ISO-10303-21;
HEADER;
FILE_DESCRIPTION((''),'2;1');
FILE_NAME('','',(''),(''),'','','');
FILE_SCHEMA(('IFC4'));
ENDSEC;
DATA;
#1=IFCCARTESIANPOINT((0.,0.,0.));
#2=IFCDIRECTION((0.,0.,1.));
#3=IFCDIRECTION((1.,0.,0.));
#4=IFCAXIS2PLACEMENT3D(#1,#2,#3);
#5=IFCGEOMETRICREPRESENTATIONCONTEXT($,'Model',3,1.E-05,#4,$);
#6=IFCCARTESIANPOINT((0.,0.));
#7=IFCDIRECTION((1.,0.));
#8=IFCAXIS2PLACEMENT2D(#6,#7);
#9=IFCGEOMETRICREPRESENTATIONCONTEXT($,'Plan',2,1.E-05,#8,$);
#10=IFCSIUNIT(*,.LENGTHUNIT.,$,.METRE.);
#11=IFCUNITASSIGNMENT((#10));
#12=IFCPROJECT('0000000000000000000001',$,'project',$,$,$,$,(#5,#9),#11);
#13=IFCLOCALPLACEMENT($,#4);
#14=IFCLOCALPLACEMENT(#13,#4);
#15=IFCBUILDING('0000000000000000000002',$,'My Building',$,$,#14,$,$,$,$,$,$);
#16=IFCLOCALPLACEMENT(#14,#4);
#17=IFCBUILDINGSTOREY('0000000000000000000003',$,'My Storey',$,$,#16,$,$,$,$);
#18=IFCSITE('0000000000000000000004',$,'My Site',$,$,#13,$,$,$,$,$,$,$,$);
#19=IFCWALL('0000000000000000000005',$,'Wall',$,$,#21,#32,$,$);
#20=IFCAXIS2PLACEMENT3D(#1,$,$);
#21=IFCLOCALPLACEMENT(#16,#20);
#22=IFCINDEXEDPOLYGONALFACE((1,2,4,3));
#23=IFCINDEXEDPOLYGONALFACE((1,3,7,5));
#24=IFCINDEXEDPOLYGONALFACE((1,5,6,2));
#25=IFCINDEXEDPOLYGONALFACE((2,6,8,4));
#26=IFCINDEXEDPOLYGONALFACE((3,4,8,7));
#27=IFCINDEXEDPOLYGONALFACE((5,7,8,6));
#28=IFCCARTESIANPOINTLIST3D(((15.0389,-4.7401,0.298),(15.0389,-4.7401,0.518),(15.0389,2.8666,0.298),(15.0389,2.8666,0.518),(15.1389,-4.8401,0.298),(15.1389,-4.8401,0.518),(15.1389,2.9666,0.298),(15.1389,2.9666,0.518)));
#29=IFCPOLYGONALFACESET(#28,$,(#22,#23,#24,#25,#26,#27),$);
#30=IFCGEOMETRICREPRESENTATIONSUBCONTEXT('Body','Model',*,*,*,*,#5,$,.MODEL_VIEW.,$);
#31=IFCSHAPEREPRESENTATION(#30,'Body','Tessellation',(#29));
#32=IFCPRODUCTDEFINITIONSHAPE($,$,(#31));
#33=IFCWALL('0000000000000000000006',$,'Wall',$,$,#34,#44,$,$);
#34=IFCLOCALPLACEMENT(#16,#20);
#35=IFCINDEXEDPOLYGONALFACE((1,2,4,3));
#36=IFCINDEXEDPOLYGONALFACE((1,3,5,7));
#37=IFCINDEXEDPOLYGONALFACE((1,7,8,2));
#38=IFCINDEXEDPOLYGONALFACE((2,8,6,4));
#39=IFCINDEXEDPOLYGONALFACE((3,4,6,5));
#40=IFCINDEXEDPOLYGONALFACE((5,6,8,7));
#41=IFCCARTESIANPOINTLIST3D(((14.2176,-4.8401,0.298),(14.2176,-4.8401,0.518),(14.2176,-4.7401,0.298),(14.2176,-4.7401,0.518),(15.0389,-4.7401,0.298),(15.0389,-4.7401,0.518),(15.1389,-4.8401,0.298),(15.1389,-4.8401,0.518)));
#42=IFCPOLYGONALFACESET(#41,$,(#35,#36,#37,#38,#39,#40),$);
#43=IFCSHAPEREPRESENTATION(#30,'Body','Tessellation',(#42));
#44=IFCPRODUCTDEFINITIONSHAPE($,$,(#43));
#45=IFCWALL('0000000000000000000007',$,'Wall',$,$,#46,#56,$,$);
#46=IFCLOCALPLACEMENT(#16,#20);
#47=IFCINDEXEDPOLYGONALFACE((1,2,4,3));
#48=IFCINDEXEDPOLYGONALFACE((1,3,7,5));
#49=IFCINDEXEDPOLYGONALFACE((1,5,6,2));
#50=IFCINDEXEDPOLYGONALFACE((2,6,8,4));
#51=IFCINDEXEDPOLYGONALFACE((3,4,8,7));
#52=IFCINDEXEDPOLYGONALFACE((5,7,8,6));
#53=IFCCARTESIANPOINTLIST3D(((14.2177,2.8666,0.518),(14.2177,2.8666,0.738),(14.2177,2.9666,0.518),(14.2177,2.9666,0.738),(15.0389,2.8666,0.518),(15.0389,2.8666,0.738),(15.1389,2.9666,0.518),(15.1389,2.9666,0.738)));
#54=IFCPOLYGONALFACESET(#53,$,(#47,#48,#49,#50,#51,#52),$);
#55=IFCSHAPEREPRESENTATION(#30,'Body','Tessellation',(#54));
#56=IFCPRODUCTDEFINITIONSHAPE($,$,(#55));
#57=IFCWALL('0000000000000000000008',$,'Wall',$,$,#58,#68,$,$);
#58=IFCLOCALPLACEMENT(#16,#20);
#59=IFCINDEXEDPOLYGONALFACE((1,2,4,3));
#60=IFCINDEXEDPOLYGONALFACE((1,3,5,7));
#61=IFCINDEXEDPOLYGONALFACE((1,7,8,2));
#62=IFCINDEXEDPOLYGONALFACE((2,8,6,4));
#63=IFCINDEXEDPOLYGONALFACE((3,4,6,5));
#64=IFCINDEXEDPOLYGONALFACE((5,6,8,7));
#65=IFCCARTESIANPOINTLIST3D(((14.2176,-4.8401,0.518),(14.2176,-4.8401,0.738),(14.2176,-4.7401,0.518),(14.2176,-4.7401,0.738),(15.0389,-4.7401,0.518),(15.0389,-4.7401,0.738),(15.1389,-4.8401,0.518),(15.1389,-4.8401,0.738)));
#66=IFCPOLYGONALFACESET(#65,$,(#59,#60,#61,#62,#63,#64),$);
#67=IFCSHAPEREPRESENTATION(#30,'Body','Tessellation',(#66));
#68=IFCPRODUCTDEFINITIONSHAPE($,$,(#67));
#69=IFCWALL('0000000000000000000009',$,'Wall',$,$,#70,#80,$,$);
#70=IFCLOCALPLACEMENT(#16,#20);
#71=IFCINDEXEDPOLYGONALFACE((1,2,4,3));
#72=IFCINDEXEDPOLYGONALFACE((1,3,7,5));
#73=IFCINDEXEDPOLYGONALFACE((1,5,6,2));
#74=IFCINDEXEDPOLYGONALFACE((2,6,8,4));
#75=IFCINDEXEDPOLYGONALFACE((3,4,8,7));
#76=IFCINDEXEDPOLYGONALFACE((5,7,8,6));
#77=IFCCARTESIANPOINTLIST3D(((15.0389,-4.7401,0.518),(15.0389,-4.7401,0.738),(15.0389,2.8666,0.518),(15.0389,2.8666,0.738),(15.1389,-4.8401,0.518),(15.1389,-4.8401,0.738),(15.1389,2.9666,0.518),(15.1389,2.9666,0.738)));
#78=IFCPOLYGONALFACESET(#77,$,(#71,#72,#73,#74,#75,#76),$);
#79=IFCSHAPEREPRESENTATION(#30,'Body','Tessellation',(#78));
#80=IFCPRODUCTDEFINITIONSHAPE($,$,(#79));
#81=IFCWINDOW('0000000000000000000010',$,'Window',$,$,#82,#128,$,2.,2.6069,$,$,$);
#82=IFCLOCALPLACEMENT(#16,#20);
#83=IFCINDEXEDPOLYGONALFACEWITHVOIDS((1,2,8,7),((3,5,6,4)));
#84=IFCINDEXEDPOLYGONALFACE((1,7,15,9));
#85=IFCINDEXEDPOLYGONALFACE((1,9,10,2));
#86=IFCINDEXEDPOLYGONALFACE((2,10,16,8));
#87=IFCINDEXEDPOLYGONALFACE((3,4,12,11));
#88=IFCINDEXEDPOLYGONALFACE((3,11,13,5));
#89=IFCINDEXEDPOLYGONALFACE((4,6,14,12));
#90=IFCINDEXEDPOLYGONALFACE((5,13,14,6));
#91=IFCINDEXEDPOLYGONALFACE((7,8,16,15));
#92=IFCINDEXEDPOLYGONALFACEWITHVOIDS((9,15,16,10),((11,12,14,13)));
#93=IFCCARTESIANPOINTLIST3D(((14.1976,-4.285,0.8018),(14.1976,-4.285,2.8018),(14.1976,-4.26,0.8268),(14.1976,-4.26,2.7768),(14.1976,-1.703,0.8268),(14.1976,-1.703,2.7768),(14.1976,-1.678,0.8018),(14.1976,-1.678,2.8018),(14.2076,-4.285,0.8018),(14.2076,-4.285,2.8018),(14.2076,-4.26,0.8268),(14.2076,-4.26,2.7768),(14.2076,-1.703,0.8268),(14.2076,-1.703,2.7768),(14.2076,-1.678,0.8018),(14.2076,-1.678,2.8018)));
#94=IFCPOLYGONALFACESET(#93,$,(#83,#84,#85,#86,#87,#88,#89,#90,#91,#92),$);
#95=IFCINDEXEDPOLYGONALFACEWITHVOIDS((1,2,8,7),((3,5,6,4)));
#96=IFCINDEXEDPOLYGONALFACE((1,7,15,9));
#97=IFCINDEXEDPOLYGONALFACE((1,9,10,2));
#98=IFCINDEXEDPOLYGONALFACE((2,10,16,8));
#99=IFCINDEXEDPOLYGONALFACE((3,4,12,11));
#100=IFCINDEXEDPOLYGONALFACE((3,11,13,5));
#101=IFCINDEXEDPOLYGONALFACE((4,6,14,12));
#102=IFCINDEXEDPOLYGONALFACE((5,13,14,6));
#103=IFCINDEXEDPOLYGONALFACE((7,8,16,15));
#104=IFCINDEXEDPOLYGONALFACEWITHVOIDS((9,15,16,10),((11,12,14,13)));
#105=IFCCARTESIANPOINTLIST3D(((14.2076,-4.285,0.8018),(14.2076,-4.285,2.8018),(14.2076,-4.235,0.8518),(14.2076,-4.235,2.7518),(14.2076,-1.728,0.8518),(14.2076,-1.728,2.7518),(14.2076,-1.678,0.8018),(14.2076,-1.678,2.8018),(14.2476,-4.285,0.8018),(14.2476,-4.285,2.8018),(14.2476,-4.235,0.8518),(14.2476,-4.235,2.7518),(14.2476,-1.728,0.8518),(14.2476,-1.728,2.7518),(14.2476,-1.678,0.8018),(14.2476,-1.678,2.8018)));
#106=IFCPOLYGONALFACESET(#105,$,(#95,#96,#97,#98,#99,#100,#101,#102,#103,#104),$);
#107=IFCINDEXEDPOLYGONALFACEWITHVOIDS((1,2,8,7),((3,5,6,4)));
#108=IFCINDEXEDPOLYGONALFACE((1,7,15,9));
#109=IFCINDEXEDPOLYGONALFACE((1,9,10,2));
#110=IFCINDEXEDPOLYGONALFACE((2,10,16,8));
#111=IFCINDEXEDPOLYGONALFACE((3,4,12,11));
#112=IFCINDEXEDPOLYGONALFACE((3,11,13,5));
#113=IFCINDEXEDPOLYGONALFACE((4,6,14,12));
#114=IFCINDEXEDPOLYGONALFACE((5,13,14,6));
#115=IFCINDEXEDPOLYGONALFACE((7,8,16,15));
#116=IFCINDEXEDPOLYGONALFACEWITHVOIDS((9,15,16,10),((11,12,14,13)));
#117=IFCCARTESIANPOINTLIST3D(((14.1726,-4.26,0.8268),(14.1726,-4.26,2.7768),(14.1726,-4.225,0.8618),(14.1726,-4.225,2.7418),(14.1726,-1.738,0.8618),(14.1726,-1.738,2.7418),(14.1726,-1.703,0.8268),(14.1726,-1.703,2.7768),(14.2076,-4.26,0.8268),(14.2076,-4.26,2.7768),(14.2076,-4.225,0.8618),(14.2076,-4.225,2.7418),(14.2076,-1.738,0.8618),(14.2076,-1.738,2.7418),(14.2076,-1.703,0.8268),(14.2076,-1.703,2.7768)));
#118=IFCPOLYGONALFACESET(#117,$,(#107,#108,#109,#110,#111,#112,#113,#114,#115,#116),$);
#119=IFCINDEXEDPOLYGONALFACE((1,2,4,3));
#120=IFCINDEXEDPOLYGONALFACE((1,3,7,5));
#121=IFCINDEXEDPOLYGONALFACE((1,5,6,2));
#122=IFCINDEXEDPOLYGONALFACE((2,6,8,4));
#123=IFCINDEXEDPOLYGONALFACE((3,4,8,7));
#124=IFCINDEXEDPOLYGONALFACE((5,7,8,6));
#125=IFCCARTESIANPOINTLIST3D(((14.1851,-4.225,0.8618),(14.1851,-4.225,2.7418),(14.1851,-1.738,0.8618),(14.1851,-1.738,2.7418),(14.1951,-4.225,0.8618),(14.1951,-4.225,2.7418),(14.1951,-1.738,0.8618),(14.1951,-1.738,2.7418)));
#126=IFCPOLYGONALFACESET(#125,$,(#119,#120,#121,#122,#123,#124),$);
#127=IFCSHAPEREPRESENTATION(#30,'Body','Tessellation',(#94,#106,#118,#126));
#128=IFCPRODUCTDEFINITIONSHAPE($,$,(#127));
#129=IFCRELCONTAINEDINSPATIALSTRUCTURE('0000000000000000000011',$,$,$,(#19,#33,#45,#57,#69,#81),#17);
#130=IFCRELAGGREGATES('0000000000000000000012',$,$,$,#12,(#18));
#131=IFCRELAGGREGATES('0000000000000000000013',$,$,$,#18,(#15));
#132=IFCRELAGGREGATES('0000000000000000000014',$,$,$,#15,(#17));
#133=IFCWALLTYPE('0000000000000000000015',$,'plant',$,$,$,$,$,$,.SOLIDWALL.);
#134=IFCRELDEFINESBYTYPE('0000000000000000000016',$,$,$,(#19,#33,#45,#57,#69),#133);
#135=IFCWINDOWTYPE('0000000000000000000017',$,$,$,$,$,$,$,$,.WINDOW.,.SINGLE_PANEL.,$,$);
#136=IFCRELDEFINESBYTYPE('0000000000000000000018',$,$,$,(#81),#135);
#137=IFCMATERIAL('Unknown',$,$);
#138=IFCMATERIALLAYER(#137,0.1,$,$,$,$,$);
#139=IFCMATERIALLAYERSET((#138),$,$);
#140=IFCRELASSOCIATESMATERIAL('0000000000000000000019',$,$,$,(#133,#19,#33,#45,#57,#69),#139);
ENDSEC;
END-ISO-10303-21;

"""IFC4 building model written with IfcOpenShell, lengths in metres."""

from ifc_helpers import new_model, entity, si_unit, frame, origin_with_axes, origin_2d_with_axis, place, context, subcontext, project, spatial, line, indexed_curve, outline, extrude, shape, source, transform, mapped, material, layer, layer_set, layer_usage, type_object, type_shapes, element, save


model = new_model("IFC4")

# Units and contexts
model_context = context("Model", 3, precision=1e-05, world=origin_with_axes())
plan_context = context("Plan", 2, precision=1e-05, world=origin_2d_with_axis())
body_context_1 = subcontext(model_context, "Body", "Model", "MODEL_VIEW")
body_context_2 = subcontext(plan_context, "Body", "Plan", "PLAN_VIEW")
ifc_project = project(units=[si_unit("LENGTHUNIT", "METRE")], contexts=[model_context, plan_context])

# Site, building, storey
site_placement = place(None, origin_with_axes())
site = spatial("IfcSite", under=ifc_project, at=site_placement, Name="My Site")
building_placement = place(site_placement, origin_with_axes())
building = spatial("IfcBuilding", under=site, at=building_placement, Name="My Building")
storey_placement = place(building_placement, origin_with_axes())
storey = spatial("IfcBuildingStorey", under=building, at=storey_placement, Name="My Storey")

# Shared definitions
ifc_material = material(Name="Unknown")

# Shared definitions
ifc_layer_1 = layer(ifc_material, 0.1)
ifc_layer_set_1 = layer_set([ifc_layer_1])
wall_type = type_object("IfcWallType", Name="plant", PredefinedType="SOLIDWALL", material=ifc_layer_set_1)

# Walls
ifc_layer_usage_1 = layer_usage(ifc_layer_set_1, "AXIS2", "POSITIVE", 0.0)
wall_1_placement = place(storey_placement, frame((15.0389, 2.8666, 0.298), z_axis=(0.0, 0.0, 1.0), x_axis=(0.0, -1.0, 0.0)))
element("IfcWall", 1, at=wall_1_placement, inside=storey, type_object=wall_type, material=ifc_layer_usage_1, Name="Wall", context=body_context_1, shape_type="SweptSolid", body=[
    extrude(outline(indexed_curve([(0.0, 0.0), (-0.1, 0.1), (7.7067, 0.1), (7.6067, 0.0)], segments=[line(1, 2, 3, 4, 1)])), origin_with_axes(), (0.0, 0.0, 1.0), 0.22),
])
ifc_layer_usage_2 = layer_usage(ifc_layer_set_1, "AXIS2", "POSITIVE", 0.0)
wall_2_placement = place(storey_placement, frame((15.0389, -4.7401, 0.298), z_axis=(0.0, 0.0, 1.0), x_axis=(-1.0, 0.0, 0.0)))
element("IfcWall", 2, at=wall_2_placement, inside=storey, type_object=wall_type, material=ifc_layer_usage_2, Name="Wall", context=body_context_1, shape_type="SweptSolid", body=[
    extrude(outline(indexed_curve([(0.0, 0.0), (-0.1, 0.1), (0.8212, 0.1), (0.8212, 0.0)], segments=[line(1, 2, 3, 4, 1)])), origin_with_axes(), (0.0, 0.0, 1.0), 0.22),
])
ifc_layer_usage_3 = layer_usage(ifc_layer_set_1, "AXIS2", "POSITIVE", 0.0)
wall_3_placement = place(storey_placement, frame((14.2177, 2.8666, 0.518), z_axis=(0.0, 0.0, 1.0), x_axis=(1.0, 0.0, 0.0)))
element("IfcWall", 3, at=wall_3_placement, inside=storey, type_object=wall_type, material=ifc_layer_usage_3, Name="Wall", context=body_context_1, shape_type="SweptSolid", body=[
    extrude(outline(indexed_curve([(0.0, 0.0), (0.0, 0.1), (0.9212, 0.1), (0.8212, 0.0)], segments=[line(1, 2, 3, 4, 1)])), origin_with_axes(), (0.0, 0.0, 1.0), 0.22),
])
ifc_layer_usage_4 = layer_usage(ifc_layer_set_1, "AXIS2", "POSITIVE", 0.0)
wall_4_placement = place(storey_placement, frame((15.0389, -4.7401, 0.518), z_axis=(0.0, 0.0, 1.0), x_axis=(-1.0, 0.0, 0.0)))
element("IfcWall", 4, at=wall_4_placement, inside=storey, type_object=wall_type, material=ifc_layer_usage_4, Name="Wall", context=body_context_1, shape_type="SweptSolid", body=[
    extrude(outline(indexed_curve([(0.0, 0.0), (-0.1, 0.1), (0.8212, 0.1), (0.8212, 0.0)], segments=[line(1, 2, 3, 4, 1)])), origin_with_axes(), (0.0, 0.0, 1.0), 0.22),
])
ifc_layer_usage_5 = layer_usage(ifc_layer_set_1, "AXIS2", "POSITIVE", 0.0)
wall_5_placement = place(storey_placement, frame((15.0389, 2.8666, 0.518), z_axis=(0.0, 0.0, 1.0), x_axis=(0.0, -1.0, 0.0)))
element("IfcWall", 5, at=wall_5_placement, inside=storey, type_object=wall_type, material=ifc_layer_usage_5, Name="Wall", context=body_context_1, shape_type="SweptSolid", body=[
    extrude(outline(indexed_curve([(0.0, 0.0), (-0.1, 0.1), (7.7067, 0.1), (7.6067, 0.0)], segments=[line(1, 2, 3, 4, 1)])), origin_with_axes(), (0.0, 0.0, 1.0), 0.22),
])

# Window
window_type = type_object("IfcWindowType", PartitioningType="SINGLE_PANEL", PredefinedType="WINDOW")
shared_shape_1 = source(origin_with_axes(), body_context_1, "Body", "SweptSolid", [
    extrude(outline(indexed_curve([(0.0, 0.0), (2.6069, 0.0), (2.6069, 2.0), (0.0, 2.0)], segments=[line(1, 2, 3, 4, 1)]), holes=[indexed_curve([(0.025, 0.025), (2.5819, 0.025), (2.5819, 1.975), (0.025, 1.975)], segments=[line(1, 2, 3, 4, 1)])]), frame((0.0, 0.09, 0.0), z_axis=(0.0, -1.0, 0.0), x_axis=(1.0, 0.0, 0.0)), (0.0, 0.0, -1.0), 0.01),
    extrude(outline(indexed_curve([(0.0, 0.0), (2.6069, 0.0), (2.6069, 2.0), (0.0, 2.0)], segments=[line(1, 2, 3, 4, 1)]), holes=[indexed_curve([(0.05, 0.05), (2.5569, 0.05), (2.5569, 1.95), (0.05, 1.95)], segments=[line(1, 2, 3, 4, 1)])]), frame((0.0, 0.05, 0.0), z_axis=(0.0, -1.0, 0.0), x_axis=(1.0, 0.0, 0.0)), (0.0, 0.0, -1.0), 0.04),
    extrude(outline(indexed_curve([(0.0, 1.95), (2.5569, 1.95), (2.5569, 0.0), (0.0, 0.0), (0.0, 1.95)]), holes=[indexed_curve([(0.035, 1.915), (2.5219, 1.915), (2.5219, 0.035), (0.035, 0.035), (0.035, 1.915)])]), frame((0.025, 0.09, 0.025), z_axis=(0.0, -1.0, 0.0), x_axis=(1.0, 0.0, 0.0)), (0.0, 0.0, -1.0), 0.035),
    extrude(outline(indexed_curve([(0.035, 0.035), (2.5219, 0.035), (2.5219, 1.915), (0.035, 1.915)], segments=[line(1, 2, 3, 4, 1)])), frame((0.025, 0.1025, 0.025), z_axis=(0.0, -1.0, 0.0), x_axis=(1.0, 0.0, 0.0)), (0.0, 0.0, -1.0), 0.01),
])
shared_shape_2 = source(origin_with_axes(), body_context_2, "Body", "Curve2D", [
    entity("IfcIndexedPolyCurve", entity("IfcCartesianPointList2D", [[0.05, 0.05], [2.5569, 0.05]])),
    entity("IfcIndexedPolyCurve", entity("IfcCartesianPointList2D", [[0.0, 0.1], [0.025, 0.1], [0.025, 0.09], [0.05, 0.09], [0.05, 0.05], [0.0, 0.05]]), [entity("IfcLineIndex", [1, 2, 3, 4, 5, 6, 1])]),
    entity("IfcIndexedPolyCurve", entity("IfcCartesianPointList2D", [[2.6069, 0.1], [2.5819, 0.1], [2.5819, 0.09], [2.5569, 0.09], [2.5569, 0.05], [2.6069, 0.05]]), [entity("IfcLineIndex", [1, 2, 3, 4, 5, 6, 1])]),
    entity("IfcIndexedPolyCurve", entity("IfcCartesianPointList2D", [[0.025, 0.09], [0.06, 0.09], [0.06, 0.125], [0.025, 0.125]]), [entity("IfcLineIndex", [1, 2, 3, 4, 1])]),
    entity("IfcIndexedPolyCurve", entity("IfcCartesianPointList2D", [[2.5819, 0.09], [2.5469, 0.09], [2.5469, 0.125], [2.5819, 0.125]]), [entity("IfcLineIndex", [1, 2, 3, 4, 1])]),
    entity("IfcIndexedPolyCurve", entity("IfcCartesianPointList2D", [[0.06, 0.09], [2.5469, 0.09]])),
    entity("IfcIndexedPolyCurve", entity("IfcCartesianPointList2D", [[0.06, 0.125], [2.5469, 0.125]])),
    entity("IfcIndexedPolyCurve", entity("IfcCartesianPointList2D", [[0.06, 0.1075], [2.5469, 0.1075]])),
])
type_shapes(window_type, [shared_shape_1, shared_shape_2])
window_placement = place(storey_placement, frame((14.2976, -4.285, 0.8018), z_axis=(0.0, 0.0, 1.0), x_axis=(0.0, 1.0, 0.0)))
element("IfcWindow", 6, at=window_placement, inside=storey, type_object=window_type, Name="Window", OverallHeight=2.0, OverallWidth=2.6069, shapes=[
    shape(body_context_1, "Body", "MappedRepresentation", [mapped(shared_shape_1, transform((0.0, 0.0, 0.0), x_axis=(1.0, 0.0, 0.0), y_axis=(0.0, 1.0, 0.0), z_axis=(0.0, 0.0, 1.0), scale=1.0))]),
    shape(body_context_2, "Body", "MappedRepresentation", [mapped(shared_shape_2, transform((0.0, 0.0, 0.0), x_axis=(1.0, 0.0, 0.0), y_axis=(0.0, 1.0, 0.0), z_axis=(0.0, 0.0, 1.0), scale=1.0))]),
])

save(model, "model.ifc")
